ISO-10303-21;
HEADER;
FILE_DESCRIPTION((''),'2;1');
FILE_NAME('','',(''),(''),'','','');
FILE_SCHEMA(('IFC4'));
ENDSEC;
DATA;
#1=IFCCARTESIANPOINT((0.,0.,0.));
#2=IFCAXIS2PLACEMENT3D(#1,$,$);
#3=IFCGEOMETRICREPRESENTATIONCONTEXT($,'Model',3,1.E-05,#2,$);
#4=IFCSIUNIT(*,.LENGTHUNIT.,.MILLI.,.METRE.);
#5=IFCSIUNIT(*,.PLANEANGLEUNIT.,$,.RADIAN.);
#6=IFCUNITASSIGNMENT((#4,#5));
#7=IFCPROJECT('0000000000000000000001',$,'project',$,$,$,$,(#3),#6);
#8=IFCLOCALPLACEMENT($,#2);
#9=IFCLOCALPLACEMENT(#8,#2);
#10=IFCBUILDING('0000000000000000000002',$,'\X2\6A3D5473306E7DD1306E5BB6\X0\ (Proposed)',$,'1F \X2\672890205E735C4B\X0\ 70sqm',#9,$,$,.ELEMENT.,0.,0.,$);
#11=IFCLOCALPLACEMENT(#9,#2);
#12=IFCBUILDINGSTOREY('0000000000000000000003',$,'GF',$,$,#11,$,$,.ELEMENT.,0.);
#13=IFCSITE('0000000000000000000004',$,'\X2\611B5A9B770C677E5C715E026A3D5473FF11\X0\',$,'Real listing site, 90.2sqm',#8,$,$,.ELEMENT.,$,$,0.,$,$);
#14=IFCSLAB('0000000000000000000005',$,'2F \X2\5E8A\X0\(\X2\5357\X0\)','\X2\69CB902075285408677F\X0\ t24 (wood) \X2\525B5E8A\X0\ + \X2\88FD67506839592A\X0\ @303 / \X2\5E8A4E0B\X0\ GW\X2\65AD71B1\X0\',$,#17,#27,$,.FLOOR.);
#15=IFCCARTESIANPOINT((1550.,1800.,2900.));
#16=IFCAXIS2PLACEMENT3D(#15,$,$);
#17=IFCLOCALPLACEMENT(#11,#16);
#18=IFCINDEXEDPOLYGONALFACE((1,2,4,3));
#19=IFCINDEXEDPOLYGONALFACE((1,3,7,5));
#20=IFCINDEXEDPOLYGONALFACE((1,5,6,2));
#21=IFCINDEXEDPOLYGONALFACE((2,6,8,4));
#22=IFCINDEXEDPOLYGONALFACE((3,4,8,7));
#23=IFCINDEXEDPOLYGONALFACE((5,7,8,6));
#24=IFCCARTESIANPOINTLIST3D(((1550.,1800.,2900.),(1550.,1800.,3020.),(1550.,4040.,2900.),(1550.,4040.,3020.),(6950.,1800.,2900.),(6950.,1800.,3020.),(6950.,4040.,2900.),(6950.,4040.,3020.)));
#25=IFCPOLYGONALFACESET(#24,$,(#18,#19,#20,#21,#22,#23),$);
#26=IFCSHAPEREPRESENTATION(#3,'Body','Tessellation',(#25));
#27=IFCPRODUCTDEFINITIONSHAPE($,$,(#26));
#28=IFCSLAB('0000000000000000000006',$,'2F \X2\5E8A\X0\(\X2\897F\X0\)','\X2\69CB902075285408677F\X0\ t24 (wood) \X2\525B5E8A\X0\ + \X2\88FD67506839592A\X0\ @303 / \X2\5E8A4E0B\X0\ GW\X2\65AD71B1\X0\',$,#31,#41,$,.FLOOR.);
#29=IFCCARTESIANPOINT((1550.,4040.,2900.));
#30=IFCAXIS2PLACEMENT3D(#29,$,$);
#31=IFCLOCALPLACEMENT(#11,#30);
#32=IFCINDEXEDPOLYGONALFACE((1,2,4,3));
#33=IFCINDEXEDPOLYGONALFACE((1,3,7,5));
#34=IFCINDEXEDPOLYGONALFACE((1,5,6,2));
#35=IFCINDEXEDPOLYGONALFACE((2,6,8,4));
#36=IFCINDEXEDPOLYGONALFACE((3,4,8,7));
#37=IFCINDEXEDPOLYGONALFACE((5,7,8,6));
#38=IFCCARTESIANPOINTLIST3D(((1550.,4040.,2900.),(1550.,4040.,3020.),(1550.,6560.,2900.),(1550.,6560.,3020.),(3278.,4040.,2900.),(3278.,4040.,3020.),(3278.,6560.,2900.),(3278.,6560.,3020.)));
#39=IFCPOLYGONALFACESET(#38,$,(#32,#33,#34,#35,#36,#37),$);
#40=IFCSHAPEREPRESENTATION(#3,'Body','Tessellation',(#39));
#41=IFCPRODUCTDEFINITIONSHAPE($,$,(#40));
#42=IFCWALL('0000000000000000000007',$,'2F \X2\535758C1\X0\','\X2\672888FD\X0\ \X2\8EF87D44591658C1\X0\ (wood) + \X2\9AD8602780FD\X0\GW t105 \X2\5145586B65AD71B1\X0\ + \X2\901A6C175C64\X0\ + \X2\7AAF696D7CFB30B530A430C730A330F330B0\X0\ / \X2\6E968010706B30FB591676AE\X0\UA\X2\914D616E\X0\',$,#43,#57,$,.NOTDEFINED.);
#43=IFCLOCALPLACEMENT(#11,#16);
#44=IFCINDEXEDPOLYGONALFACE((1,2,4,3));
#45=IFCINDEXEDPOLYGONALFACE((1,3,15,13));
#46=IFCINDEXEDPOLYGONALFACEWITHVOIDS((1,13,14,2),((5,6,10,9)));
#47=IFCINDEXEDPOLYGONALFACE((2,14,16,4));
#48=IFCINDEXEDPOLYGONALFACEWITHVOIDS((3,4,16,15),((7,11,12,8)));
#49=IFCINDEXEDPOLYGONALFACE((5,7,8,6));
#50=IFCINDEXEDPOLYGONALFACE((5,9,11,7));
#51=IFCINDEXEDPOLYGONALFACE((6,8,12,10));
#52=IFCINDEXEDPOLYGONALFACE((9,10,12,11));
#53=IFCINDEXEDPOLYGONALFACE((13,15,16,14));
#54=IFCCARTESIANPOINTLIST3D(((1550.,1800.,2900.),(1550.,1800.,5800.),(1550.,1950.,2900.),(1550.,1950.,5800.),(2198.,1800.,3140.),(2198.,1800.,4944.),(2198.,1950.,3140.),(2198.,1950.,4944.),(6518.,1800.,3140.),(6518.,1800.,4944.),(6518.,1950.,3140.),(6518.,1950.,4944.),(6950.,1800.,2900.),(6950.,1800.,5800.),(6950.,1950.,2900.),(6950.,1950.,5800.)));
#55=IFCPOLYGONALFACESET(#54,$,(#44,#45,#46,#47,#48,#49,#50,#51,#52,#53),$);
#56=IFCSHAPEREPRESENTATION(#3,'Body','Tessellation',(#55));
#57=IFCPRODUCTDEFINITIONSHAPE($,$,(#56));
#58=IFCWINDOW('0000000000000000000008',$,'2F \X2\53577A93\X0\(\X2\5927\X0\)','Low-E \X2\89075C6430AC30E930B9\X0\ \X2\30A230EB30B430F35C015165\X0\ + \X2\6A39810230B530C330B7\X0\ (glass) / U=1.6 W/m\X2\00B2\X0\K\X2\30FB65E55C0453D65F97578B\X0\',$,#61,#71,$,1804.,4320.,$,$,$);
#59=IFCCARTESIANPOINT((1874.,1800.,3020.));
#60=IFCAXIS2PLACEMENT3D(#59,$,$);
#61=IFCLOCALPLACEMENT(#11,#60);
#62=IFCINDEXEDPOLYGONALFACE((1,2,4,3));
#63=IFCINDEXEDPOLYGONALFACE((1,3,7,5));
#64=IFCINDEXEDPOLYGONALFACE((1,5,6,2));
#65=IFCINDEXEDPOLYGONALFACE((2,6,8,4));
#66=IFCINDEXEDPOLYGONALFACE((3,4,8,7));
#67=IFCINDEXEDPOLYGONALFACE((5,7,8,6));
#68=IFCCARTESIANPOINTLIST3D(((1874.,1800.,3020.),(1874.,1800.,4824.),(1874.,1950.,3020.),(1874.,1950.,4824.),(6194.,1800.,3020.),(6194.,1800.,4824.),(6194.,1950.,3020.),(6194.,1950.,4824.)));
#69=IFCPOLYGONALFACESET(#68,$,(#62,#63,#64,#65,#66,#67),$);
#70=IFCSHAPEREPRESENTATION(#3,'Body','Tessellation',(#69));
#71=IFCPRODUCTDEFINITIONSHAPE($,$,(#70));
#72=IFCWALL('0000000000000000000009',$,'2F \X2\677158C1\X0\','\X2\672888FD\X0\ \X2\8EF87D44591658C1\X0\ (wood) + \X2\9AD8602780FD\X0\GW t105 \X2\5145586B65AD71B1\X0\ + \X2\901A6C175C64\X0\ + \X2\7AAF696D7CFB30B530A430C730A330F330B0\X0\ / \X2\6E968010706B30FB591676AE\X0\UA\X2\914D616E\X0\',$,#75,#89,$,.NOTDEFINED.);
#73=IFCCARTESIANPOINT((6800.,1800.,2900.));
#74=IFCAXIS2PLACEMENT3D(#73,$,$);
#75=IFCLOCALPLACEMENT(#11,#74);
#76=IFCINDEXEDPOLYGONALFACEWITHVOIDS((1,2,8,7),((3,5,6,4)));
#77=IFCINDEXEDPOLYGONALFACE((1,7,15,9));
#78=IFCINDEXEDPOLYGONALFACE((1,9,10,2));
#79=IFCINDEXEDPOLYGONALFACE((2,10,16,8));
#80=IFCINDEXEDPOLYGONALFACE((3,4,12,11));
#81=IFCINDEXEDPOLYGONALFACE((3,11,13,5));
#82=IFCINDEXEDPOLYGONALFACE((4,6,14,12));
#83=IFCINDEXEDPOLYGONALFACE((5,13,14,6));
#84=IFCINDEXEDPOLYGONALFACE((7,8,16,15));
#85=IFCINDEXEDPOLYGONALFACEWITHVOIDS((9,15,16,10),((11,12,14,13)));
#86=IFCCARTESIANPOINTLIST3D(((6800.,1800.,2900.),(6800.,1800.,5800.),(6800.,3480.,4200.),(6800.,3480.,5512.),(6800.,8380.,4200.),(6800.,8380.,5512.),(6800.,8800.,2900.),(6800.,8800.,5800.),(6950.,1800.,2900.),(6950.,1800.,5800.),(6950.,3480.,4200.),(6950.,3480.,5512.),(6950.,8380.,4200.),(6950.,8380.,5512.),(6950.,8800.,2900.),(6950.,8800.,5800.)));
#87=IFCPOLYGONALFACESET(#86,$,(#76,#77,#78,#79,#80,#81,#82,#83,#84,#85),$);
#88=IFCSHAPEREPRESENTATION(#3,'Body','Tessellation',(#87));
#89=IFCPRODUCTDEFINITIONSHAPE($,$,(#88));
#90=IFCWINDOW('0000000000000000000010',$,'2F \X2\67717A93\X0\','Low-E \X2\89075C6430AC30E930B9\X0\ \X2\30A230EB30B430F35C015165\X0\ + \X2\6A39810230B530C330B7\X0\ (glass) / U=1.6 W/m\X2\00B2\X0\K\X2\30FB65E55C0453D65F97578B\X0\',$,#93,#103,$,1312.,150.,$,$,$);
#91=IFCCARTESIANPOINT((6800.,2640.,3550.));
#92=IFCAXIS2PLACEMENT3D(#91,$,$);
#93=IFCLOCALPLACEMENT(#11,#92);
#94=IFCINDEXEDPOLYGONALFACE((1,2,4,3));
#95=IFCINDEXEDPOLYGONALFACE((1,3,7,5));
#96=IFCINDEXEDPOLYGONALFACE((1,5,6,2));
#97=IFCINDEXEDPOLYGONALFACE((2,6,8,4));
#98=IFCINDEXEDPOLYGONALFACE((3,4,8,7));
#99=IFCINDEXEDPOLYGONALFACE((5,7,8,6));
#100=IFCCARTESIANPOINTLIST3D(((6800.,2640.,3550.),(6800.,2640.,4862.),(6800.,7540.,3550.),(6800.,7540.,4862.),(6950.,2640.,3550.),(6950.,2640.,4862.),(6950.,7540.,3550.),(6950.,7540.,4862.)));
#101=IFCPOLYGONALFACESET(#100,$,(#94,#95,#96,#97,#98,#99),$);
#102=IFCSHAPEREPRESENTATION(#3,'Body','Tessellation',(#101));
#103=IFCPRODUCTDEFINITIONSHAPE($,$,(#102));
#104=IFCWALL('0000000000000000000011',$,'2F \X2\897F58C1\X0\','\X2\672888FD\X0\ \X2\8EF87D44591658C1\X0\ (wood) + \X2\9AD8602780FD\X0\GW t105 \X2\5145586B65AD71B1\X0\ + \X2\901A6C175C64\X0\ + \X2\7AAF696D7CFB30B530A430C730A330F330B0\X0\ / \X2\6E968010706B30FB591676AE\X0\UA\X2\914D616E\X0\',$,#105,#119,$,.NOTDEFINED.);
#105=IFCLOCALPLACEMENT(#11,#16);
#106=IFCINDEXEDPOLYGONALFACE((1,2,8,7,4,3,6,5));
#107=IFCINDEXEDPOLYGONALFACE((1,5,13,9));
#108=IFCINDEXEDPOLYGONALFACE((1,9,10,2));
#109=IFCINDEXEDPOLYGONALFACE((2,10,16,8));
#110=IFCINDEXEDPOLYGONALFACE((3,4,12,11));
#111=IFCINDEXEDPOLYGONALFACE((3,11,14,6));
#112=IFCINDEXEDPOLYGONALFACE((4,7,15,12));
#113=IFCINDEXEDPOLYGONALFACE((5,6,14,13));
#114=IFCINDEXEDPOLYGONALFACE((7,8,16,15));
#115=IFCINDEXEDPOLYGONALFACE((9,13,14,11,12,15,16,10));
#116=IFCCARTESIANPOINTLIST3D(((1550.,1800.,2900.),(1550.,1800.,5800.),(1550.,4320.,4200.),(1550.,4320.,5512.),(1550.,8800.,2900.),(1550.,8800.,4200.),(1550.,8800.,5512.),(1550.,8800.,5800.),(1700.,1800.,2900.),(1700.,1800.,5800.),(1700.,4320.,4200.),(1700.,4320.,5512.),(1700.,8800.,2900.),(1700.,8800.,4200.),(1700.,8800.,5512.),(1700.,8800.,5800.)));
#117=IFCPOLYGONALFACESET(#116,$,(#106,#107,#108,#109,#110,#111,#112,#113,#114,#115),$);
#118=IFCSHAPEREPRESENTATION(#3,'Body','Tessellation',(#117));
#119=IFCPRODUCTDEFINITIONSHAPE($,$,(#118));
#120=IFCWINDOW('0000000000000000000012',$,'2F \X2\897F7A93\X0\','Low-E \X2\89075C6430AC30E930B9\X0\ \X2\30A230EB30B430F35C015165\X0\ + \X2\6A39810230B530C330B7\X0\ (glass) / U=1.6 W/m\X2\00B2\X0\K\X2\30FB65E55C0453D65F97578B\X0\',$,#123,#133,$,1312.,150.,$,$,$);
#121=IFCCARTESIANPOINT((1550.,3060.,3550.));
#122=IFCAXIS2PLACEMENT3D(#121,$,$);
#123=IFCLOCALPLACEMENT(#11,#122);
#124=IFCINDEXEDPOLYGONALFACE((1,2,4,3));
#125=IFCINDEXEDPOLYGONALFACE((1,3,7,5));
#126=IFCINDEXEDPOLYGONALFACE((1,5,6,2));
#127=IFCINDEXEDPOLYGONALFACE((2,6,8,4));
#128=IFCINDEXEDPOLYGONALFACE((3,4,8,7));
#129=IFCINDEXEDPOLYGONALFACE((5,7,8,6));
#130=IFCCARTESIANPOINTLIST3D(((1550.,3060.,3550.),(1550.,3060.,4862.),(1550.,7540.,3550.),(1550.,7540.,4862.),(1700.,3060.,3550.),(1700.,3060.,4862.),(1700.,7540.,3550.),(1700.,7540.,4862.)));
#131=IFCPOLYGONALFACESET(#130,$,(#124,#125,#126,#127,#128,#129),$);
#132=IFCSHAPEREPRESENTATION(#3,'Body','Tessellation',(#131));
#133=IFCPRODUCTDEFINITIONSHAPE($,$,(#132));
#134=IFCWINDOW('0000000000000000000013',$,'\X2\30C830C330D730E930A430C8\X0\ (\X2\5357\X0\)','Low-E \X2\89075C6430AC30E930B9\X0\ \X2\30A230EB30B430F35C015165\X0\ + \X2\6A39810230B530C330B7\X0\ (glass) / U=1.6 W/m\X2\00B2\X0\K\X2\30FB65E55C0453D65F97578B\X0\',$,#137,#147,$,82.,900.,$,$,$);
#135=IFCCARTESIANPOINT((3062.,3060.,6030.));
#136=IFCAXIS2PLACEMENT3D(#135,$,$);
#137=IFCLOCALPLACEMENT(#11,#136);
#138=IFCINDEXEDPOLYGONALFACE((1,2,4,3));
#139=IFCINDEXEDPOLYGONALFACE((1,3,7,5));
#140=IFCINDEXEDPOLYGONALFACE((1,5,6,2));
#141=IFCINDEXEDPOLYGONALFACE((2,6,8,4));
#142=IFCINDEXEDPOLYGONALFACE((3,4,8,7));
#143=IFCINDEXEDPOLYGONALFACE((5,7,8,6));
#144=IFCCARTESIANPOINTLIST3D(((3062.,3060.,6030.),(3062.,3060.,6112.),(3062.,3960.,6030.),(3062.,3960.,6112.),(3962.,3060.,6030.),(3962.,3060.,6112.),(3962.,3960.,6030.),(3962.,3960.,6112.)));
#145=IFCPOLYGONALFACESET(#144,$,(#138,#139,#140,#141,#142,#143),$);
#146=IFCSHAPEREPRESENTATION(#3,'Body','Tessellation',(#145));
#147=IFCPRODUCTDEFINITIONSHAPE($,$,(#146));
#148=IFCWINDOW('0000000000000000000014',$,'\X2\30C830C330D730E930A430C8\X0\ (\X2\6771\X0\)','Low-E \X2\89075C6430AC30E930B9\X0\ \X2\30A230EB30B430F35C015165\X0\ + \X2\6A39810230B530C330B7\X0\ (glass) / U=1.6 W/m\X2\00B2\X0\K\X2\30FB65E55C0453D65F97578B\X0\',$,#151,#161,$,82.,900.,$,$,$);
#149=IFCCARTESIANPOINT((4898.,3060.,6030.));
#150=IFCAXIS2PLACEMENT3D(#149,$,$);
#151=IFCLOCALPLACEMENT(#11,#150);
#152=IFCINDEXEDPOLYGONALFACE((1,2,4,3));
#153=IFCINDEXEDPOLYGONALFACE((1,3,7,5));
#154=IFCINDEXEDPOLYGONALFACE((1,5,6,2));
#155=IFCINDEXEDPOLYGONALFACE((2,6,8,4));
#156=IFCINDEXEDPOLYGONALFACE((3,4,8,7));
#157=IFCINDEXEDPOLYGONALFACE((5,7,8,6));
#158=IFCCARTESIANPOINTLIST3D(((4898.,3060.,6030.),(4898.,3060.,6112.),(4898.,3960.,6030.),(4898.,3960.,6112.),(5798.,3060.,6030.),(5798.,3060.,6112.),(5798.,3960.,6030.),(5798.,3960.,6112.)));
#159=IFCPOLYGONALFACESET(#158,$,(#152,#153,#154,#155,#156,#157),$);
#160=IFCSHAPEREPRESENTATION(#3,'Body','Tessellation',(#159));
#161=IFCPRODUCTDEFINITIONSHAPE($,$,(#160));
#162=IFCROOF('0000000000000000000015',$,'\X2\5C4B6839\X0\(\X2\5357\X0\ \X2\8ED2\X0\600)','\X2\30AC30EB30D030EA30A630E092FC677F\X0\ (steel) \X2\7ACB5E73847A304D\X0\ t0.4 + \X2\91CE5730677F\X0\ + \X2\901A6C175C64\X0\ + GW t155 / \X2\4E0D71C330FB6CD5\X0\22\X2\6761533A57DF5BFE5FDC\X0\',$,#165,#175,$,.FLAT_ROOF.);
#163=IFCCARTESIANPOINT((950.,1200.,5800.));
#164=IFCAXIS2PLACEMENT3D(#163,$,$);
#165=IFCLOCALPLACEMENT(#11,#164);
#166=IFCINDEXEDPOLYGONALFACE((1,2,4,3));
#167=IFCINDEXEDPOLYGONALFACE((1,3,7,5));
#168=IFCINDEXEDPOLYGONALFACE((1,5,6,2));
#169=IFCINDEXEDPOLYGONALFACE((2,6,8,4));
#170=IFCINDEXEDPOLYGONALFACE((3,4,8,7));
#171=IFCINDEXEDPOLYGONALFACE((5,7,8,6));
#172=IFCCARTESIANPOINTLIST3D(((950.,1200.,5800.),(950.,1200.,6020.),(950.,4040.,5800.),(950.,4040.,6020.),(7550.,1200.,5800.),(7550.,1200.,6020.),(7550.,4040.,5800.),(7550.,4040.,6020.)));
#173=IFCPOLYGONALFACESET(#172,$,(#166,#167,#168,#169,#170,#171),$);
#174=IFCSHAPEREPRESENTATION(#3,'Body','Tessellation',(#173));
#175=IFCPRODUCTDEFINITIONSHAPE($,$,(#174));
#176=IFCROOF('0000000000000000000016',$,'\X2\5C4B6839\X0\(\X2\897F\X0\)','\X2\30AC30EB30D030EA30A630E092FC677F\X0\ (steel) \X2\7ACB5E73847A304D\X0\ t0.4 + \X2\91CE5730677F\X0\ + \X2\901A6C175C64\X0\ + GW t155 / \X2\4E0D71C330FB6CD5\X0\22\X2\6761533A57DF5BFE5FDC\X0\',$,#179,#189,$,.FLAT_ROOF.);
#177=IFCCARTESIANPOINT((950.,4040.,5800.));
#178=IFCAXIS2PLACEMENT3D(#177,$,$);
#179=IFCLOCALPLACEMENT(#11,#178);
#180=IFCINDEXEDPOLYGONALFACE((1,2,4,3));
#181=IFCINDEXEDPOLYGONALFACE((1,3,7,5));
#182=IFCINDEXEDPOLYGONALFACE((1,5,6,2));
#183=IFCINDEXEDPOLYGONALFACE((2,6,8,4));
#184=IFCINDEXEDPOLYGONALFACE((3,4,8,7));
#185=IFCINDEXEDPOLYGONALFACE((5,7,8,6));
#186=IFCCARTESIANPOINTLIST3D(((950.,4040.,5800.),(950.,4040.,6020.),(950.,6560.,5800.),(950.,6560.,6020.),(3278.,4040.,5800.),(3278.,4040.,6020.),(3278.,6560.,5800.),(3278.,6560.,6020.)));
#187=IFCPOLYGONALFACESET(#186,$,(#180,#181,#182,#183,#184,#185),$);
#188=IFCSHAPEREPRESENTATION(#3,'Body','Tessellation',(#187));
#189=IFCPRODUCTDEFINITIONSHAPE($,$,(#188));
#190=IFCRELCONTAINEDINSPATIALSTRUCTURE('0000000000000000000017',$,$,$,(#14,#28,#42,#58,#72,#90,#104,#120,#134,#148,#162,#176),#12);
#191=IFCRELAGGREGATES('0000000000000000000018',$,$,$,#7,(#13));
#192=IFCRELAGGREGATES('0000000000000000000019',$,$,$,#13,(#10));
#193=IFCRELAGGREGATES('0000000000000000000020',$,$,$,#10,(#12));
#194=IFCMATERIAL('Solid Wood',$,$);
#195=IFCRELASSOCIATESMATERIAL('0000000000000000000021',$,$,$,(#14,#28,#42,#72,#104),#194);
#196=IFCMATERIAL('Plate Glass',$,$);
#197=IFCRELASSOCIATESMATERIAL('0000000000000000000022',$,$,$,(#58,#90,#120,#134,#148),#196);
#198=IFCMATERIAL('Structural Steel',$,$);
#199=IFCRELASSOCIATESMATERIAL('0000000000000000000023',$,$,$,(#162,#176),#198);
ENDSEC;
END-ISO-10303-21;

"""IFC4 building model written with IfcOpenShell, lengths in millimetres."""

from ifc_helpers import new_model, si_unit, frame, frame_2d, origin, place, context, project, spatial, rectangle, extrude, material, element, fill, save


model = new_model("IFC4")

# Units and contexts
model_context = context("Model", 3, precision=1e-05, world=origin())
ifc_project = project(units=[si_unit("LENGTHUNIT", "METRE", prefix="MILLI"), si_unit("PLANEANGLEUNIT", "RADIAN")], contexts=[model_context])

# Site, building, storey
site_placement = place(None, origin())
site = spatial("IfcSite", under=ifc_project, at=site_placement, Name="愛媛県松山市樽味１", ObjectType="Real listing site, 90.2sqm", CompositionType="ELEMENT", RefElevation=0.0)
building_placement = place(site_placement, origin())
building = spatial("IfcBuilding", under=site, at=building_placement, Name="樽味の緑の家 (Proposed)", ObjectType="1F 木造平屋 70sqm", CompositionType="ELEMENT", ElevationOfRefHeight=0.0, ElevationOfTerrain=0.0)
storey_placement = place(building_placement, origin())
storey = spatial("IfcBuildingStorey", under=building, at=storey_placement, Name="GF", CompositionType="ELEMENT", Elevation=0.0)

# Slabs
ifc_material_1 = material(Name="Solid Wood")
slab_1_placement = place(storey_placement, frame((1550.0, 1800.0, 2900.0)))
element("IfcSlab", 1, at=slab_1_placement, inside=storey, material=ifc_material_1, Name="2F 床(南)", Description="構造用合板 t24 (wood) 剛床 + 製材根太 @303 / 床下 GW断熱", PredefinedType="FLOOR", context=model_context, shape_type="SweptSolid", body=[
    extrude(rectangle(XDim=5400.0, YDim=2240.0, at=frame_2d((2700.0, 1120.0))), frame((1550.0, 1800.0, 2900.0)), (0.0, 0.0, 1.0), 120.0),
])
slab_2_placement = place(storey_placement, frame((1550.0, 4040.0, 2900.0)))
element("IfcSlab", 2, at=slab_2_placement, inside=storey, material=ifc_material_1, Name="2F 床(西)", Description="構造用合板 t24 (wood) 剛床 + 製材根太 @303 / 床下 GW断熱", PredefinedType="FLOOR", context=model_context, shape_type="SweptSolid", body=[
    extrude(rectangle(XDim=1728.0, YDim=2520.0, at=frame_2d((864.0, 1260.0))), frame((1550.0, 4040.0, 2900.0)), (0.0, 0.0, 1.0), 120.0),
])

# Walls, openings, windows
wall_1_placement = place(storey_placement, frame((1550.0, 1800.0, 2900.0)))
wall_1 = element("IfcWall", 3, at=wall_1_placement, inside=storey, material=ifc_material_1, Name="2F 南壁", Description="木製 軸組外壁 (wood) + 高性能GW t105 充填断熱 + 通気層 + 窯業系サイディング / 準耐火・外皮UA配慮", PredefinedType="NOTDEFINED", context=model_context, shape_type="SweptSolid", body=[
    extrude(rectangle(XDim=5400.0, YDim=150.0, at=frame_2d((2700.0, 75.0))), frame((1550.0, 1800.0, 2900.0)), (0.0, 0.0, 1.0), 2900.0),
])
opening_1_placement = place(storey_placement, frame((1874.0, 1800.0, 3020.0)))
opening_1 = element("IfcOpeningElement", 4, at=opening_1_placement, cuts=wall_1, PredefinedType="NOTDEFINED", context=model_context, shape_type="SweptSolid", body=[
    extrude(rectangle(XDim=4320.0, YDim=150.0, at=frame_2d((2160.0, 75.0))), frame((1874.0, 1800.0, 3020.0)), (0.0, 0.0, 1.0), 1804.0),
])
ifc_material_2 = material(Name="Plate Glass")
window_1_placement = place(storey_placement, frame((1874.0, 1800.0, 3020.0)))
window_1 = element("IfcWindow", 5, at=window_1_placement, inside=storey, material=ifc_material_2, Name="2F 南窓(大)", Description="Low-E 複層ガラス アルゴン封入 + 樹脂サッシ (glass) / U=1.6 W/m²K・日射取得型", OverallHeight=1804.0, OverallWidth=4320.0, context=model_context, shape_type="SweptSolid", body=[
    extrude(rectangle(XDim=4320.0, YDim=150.0, at=frame_2d((2160.0, 75.0))), frame((1874.0, 1800.0, 3020.0)), (0.0, 0.0, 1.0), 1804.0),
])
fill(opening_1, window_1)
wall_2_placement = place(storey_placement, frame((6800.0, 1800.0, 2900.0)))
wall_2 = element("IfcWall", 6, at=wall_2_placement, inside=storey, material=ifc_material_1, Name="2F 東壁", Description="木製 軸組外壁 (wood) + 高性能GW t105 充填断熱 + 通気層 + 窯業系サイディング / 準耐火・外皮UA配慮", PredefinedType="NOTDEFINED", context=model_context, shape_type="SweptSolid", body=[
    extrude(rectangle(XDim=150.0, YDim=7000.0, at=frame_2d((75.0, 3500.0))), frame((6800.0, 1800.0, 2900.0)), (0.0, 0.0, 1.0), 2900.0),
])
opening_2_placement = place(storey_placement, frame((6800.0, 2640.0, 3550.0)))
opening_2 = element("IfcOpeningElement", 7, at=opening_2_placement, cuts=wall_2, PredefinedType="NOTDEFINED", context=model_context, shape_type="SweptSolid", body=[
    extrude(rectangle(XDim=150.0, YDim=4900.0, at=frame_2d((75.0, 2450.0))), frame((6800.0, 2640.0, 3550.0)), (0.0, 0.0, 1.0), 1312.0),
])
window_2_placement = place(storey_placement, frame((6800.0, 2640.0, 3550.0)))
window_2 = element("IfcWindow", 8, at=window_2_placement, inside=storey, material=ifc_material_2, Name="2F 東窓", Description="Low-E 複層ガラス アルゴン封入 + 樹脂サッシ (glass) / U=1.6 W/m²K・日射取得型", OverallHeight=1312.0, OverallWidth=150.0, context=model_context, shape_type="SweptSolid", body=[
    extrude(rectangle(XDim=150.0, YDim=4900.0, at=frame_2d((75.0, 2450.0))), frame((6800.0, 2640.0, 3550.0)), (0.0, 0.0, 1.0), 1312.0),
])
fill(opening_2, window_2)
wall_3_placement = place(storey_placement, frame((1550.0, 1800.0, 2900.0)))
wall_3 = element("IfcWall", 9, at=wall_3_placement, inside=storey, material=ifc_material_1, Name="2F 西壁", Description="木製 軸組外壁 (wood) + 高性能GW t105 充填断熱 + 通気層 + 窯業系サイディング / 準耐火・外皮UA配慮", PredefinedType="NOTDEFINED", context=model_context, shape_type="SweptSolid", body=[
    extrude(rectangle(XDim=150.0, YDim=7000.0, at=frame_2d((75.0, 3500.0))), frame((1550.0, 1800.0, 2900.0)), (0.0, 0.0, 1.0), 2900.0),
])
opening_3_placement = place(storey_placement, frame((1550.0, 3060.0, 3550.0)))
opening_3 = element("IfcOpeningElement", 10, at=opening_3_placement, cuts=wall_3, PredefinedType="NOTDEFINED", context=model_context, shape_type="SweptSolid", body=[
    extrude(rectangle(XDim=150.0, YDim=4480.0, at=frame_2d((75.0, 2240.0))), frame((1550.0, 3060.0, 3550.0)), (0.0, 0.0, 1.0), 1312.0),
])
window_3_placement = place(storey_placement, frame((1550.0, 3060.0, 3550.0)))
window_3 = element("IfcWindow", 11, at=window_3_placement, inside=storey, material=ifc_material_2, Name="2F 西窓", Description="Low-E 複層ガラス アルゴン封入 + 樹脂サッシ (glass) / U=1.6 W/m²K・日射取得型", OverallHeight=1312.0, OverallWidth=150.0, context=model_context, shape_type="SweptSolid", body=[
    extrude(rectangle(XDim=150.0, YDim=4480.0, at=frame_2d((75.0, 2240.0))), frame((1550.0, 3060.0, 3550.0)), (0.0, 0.0, 1.0), 1312.0),
])
fill(opening_3, window_3)

# Windows
window_4_placement = place(storey_placement, frame((3062.0, 3060.0, 6030.0)))
element("IfcWindow", 12, at=window_4_placement, inside=storey, material=ifc_material_2, Name="トップライト (南)", Description="Low-E 複層ガラス アルゴン封入 + 樹脂サッシ (glass) / U=1.6 W/m²K・日射取得型", OverallHeight=82.0, OverallWidth=900.0, context=model_context, shape_type="SweptSolid", body=[
    extrude(rectangle(XDim=900.0, YDim=900.0, at=frame_2d((450.0, 450.0))), frame((3062.0, 3060.0, 6030.0)), (0.0, 0.0, 1.0), 82.0),
])
window_5_placement = place(storey_placement, frame((4898.0, 3060.0, 6030.0)))
element("IfcWindow", 13, at=window_5_placement, inside=storey, material=ifc_material_2, Name="トップライト (東)", Description="Low-E 複層ガラス アルゴン封入 + 樹脂サッシ (glass) / U=1.6 W/m²K・日射取得型", OverallHeight=82.0, OverallWidth=900.0, context=model_context, shape_type="SweptSolid", body=[
    extrude(rectangle(XDim=900.0, YDim=900.0, at=frame_2d((450.0, 450.0))), frame((4898.0, 3060.0, 6030.0)), (0.0, 0.0, 1.0), 82.0),
])

# Roofs
ifc_material_3 = material(Name="Structural Steel")
roof_1_placement = place(storey_placement, frame((950.0, 1200.0, 5800.0)))
element("IfcRoof", 14, at=roof_1_placement, inside=storey, material=ifc_material_3, Name="屋根(南 軒600)", Description="ガルバリウム鋼板 (steel) 立平葺き t0.4 + 野地板 + 通気層 + GW t155 / 不燃・法22条区域対応", PredefinedType="FLAT_ROOF", context=model_context, shape_type="SweptSolid", body=[
    extrude(rectangle(XDim=6600.0, YDim=2840.0, at=frame_2d((3300.0, 1420.0))), frame((950.0, 1200.0, 5800.0)), (0.0, 0.0, 1.0), 220.0),
])
roof_2_placement = place(storey_placement, frame((950.0, 4040.0, 5800.0)))
element("IfcRoof", 15, at=roof_2_placement, inside=storey, material=ifc_material_3, Name="屋根(西)", Description="ガルバリウム鋼板 (steel) 立平葺き t0.4 + 野地板 + 通気層 + GW t155 / 不燃・法22条区域対応", PredefinedType="FLAT_ROOF", context=model_context, shape_type="SweptSolid", body=[
    extrude(rectangle(XDim=2328.0, YDim=2520.0, at=frame_2d((1164.0, 1260.0))), frame((950.0, 4040.0, 5800.0)), (0.0, 0.0, 1.0), 220.0),
])

save(model, "model.ifc")
